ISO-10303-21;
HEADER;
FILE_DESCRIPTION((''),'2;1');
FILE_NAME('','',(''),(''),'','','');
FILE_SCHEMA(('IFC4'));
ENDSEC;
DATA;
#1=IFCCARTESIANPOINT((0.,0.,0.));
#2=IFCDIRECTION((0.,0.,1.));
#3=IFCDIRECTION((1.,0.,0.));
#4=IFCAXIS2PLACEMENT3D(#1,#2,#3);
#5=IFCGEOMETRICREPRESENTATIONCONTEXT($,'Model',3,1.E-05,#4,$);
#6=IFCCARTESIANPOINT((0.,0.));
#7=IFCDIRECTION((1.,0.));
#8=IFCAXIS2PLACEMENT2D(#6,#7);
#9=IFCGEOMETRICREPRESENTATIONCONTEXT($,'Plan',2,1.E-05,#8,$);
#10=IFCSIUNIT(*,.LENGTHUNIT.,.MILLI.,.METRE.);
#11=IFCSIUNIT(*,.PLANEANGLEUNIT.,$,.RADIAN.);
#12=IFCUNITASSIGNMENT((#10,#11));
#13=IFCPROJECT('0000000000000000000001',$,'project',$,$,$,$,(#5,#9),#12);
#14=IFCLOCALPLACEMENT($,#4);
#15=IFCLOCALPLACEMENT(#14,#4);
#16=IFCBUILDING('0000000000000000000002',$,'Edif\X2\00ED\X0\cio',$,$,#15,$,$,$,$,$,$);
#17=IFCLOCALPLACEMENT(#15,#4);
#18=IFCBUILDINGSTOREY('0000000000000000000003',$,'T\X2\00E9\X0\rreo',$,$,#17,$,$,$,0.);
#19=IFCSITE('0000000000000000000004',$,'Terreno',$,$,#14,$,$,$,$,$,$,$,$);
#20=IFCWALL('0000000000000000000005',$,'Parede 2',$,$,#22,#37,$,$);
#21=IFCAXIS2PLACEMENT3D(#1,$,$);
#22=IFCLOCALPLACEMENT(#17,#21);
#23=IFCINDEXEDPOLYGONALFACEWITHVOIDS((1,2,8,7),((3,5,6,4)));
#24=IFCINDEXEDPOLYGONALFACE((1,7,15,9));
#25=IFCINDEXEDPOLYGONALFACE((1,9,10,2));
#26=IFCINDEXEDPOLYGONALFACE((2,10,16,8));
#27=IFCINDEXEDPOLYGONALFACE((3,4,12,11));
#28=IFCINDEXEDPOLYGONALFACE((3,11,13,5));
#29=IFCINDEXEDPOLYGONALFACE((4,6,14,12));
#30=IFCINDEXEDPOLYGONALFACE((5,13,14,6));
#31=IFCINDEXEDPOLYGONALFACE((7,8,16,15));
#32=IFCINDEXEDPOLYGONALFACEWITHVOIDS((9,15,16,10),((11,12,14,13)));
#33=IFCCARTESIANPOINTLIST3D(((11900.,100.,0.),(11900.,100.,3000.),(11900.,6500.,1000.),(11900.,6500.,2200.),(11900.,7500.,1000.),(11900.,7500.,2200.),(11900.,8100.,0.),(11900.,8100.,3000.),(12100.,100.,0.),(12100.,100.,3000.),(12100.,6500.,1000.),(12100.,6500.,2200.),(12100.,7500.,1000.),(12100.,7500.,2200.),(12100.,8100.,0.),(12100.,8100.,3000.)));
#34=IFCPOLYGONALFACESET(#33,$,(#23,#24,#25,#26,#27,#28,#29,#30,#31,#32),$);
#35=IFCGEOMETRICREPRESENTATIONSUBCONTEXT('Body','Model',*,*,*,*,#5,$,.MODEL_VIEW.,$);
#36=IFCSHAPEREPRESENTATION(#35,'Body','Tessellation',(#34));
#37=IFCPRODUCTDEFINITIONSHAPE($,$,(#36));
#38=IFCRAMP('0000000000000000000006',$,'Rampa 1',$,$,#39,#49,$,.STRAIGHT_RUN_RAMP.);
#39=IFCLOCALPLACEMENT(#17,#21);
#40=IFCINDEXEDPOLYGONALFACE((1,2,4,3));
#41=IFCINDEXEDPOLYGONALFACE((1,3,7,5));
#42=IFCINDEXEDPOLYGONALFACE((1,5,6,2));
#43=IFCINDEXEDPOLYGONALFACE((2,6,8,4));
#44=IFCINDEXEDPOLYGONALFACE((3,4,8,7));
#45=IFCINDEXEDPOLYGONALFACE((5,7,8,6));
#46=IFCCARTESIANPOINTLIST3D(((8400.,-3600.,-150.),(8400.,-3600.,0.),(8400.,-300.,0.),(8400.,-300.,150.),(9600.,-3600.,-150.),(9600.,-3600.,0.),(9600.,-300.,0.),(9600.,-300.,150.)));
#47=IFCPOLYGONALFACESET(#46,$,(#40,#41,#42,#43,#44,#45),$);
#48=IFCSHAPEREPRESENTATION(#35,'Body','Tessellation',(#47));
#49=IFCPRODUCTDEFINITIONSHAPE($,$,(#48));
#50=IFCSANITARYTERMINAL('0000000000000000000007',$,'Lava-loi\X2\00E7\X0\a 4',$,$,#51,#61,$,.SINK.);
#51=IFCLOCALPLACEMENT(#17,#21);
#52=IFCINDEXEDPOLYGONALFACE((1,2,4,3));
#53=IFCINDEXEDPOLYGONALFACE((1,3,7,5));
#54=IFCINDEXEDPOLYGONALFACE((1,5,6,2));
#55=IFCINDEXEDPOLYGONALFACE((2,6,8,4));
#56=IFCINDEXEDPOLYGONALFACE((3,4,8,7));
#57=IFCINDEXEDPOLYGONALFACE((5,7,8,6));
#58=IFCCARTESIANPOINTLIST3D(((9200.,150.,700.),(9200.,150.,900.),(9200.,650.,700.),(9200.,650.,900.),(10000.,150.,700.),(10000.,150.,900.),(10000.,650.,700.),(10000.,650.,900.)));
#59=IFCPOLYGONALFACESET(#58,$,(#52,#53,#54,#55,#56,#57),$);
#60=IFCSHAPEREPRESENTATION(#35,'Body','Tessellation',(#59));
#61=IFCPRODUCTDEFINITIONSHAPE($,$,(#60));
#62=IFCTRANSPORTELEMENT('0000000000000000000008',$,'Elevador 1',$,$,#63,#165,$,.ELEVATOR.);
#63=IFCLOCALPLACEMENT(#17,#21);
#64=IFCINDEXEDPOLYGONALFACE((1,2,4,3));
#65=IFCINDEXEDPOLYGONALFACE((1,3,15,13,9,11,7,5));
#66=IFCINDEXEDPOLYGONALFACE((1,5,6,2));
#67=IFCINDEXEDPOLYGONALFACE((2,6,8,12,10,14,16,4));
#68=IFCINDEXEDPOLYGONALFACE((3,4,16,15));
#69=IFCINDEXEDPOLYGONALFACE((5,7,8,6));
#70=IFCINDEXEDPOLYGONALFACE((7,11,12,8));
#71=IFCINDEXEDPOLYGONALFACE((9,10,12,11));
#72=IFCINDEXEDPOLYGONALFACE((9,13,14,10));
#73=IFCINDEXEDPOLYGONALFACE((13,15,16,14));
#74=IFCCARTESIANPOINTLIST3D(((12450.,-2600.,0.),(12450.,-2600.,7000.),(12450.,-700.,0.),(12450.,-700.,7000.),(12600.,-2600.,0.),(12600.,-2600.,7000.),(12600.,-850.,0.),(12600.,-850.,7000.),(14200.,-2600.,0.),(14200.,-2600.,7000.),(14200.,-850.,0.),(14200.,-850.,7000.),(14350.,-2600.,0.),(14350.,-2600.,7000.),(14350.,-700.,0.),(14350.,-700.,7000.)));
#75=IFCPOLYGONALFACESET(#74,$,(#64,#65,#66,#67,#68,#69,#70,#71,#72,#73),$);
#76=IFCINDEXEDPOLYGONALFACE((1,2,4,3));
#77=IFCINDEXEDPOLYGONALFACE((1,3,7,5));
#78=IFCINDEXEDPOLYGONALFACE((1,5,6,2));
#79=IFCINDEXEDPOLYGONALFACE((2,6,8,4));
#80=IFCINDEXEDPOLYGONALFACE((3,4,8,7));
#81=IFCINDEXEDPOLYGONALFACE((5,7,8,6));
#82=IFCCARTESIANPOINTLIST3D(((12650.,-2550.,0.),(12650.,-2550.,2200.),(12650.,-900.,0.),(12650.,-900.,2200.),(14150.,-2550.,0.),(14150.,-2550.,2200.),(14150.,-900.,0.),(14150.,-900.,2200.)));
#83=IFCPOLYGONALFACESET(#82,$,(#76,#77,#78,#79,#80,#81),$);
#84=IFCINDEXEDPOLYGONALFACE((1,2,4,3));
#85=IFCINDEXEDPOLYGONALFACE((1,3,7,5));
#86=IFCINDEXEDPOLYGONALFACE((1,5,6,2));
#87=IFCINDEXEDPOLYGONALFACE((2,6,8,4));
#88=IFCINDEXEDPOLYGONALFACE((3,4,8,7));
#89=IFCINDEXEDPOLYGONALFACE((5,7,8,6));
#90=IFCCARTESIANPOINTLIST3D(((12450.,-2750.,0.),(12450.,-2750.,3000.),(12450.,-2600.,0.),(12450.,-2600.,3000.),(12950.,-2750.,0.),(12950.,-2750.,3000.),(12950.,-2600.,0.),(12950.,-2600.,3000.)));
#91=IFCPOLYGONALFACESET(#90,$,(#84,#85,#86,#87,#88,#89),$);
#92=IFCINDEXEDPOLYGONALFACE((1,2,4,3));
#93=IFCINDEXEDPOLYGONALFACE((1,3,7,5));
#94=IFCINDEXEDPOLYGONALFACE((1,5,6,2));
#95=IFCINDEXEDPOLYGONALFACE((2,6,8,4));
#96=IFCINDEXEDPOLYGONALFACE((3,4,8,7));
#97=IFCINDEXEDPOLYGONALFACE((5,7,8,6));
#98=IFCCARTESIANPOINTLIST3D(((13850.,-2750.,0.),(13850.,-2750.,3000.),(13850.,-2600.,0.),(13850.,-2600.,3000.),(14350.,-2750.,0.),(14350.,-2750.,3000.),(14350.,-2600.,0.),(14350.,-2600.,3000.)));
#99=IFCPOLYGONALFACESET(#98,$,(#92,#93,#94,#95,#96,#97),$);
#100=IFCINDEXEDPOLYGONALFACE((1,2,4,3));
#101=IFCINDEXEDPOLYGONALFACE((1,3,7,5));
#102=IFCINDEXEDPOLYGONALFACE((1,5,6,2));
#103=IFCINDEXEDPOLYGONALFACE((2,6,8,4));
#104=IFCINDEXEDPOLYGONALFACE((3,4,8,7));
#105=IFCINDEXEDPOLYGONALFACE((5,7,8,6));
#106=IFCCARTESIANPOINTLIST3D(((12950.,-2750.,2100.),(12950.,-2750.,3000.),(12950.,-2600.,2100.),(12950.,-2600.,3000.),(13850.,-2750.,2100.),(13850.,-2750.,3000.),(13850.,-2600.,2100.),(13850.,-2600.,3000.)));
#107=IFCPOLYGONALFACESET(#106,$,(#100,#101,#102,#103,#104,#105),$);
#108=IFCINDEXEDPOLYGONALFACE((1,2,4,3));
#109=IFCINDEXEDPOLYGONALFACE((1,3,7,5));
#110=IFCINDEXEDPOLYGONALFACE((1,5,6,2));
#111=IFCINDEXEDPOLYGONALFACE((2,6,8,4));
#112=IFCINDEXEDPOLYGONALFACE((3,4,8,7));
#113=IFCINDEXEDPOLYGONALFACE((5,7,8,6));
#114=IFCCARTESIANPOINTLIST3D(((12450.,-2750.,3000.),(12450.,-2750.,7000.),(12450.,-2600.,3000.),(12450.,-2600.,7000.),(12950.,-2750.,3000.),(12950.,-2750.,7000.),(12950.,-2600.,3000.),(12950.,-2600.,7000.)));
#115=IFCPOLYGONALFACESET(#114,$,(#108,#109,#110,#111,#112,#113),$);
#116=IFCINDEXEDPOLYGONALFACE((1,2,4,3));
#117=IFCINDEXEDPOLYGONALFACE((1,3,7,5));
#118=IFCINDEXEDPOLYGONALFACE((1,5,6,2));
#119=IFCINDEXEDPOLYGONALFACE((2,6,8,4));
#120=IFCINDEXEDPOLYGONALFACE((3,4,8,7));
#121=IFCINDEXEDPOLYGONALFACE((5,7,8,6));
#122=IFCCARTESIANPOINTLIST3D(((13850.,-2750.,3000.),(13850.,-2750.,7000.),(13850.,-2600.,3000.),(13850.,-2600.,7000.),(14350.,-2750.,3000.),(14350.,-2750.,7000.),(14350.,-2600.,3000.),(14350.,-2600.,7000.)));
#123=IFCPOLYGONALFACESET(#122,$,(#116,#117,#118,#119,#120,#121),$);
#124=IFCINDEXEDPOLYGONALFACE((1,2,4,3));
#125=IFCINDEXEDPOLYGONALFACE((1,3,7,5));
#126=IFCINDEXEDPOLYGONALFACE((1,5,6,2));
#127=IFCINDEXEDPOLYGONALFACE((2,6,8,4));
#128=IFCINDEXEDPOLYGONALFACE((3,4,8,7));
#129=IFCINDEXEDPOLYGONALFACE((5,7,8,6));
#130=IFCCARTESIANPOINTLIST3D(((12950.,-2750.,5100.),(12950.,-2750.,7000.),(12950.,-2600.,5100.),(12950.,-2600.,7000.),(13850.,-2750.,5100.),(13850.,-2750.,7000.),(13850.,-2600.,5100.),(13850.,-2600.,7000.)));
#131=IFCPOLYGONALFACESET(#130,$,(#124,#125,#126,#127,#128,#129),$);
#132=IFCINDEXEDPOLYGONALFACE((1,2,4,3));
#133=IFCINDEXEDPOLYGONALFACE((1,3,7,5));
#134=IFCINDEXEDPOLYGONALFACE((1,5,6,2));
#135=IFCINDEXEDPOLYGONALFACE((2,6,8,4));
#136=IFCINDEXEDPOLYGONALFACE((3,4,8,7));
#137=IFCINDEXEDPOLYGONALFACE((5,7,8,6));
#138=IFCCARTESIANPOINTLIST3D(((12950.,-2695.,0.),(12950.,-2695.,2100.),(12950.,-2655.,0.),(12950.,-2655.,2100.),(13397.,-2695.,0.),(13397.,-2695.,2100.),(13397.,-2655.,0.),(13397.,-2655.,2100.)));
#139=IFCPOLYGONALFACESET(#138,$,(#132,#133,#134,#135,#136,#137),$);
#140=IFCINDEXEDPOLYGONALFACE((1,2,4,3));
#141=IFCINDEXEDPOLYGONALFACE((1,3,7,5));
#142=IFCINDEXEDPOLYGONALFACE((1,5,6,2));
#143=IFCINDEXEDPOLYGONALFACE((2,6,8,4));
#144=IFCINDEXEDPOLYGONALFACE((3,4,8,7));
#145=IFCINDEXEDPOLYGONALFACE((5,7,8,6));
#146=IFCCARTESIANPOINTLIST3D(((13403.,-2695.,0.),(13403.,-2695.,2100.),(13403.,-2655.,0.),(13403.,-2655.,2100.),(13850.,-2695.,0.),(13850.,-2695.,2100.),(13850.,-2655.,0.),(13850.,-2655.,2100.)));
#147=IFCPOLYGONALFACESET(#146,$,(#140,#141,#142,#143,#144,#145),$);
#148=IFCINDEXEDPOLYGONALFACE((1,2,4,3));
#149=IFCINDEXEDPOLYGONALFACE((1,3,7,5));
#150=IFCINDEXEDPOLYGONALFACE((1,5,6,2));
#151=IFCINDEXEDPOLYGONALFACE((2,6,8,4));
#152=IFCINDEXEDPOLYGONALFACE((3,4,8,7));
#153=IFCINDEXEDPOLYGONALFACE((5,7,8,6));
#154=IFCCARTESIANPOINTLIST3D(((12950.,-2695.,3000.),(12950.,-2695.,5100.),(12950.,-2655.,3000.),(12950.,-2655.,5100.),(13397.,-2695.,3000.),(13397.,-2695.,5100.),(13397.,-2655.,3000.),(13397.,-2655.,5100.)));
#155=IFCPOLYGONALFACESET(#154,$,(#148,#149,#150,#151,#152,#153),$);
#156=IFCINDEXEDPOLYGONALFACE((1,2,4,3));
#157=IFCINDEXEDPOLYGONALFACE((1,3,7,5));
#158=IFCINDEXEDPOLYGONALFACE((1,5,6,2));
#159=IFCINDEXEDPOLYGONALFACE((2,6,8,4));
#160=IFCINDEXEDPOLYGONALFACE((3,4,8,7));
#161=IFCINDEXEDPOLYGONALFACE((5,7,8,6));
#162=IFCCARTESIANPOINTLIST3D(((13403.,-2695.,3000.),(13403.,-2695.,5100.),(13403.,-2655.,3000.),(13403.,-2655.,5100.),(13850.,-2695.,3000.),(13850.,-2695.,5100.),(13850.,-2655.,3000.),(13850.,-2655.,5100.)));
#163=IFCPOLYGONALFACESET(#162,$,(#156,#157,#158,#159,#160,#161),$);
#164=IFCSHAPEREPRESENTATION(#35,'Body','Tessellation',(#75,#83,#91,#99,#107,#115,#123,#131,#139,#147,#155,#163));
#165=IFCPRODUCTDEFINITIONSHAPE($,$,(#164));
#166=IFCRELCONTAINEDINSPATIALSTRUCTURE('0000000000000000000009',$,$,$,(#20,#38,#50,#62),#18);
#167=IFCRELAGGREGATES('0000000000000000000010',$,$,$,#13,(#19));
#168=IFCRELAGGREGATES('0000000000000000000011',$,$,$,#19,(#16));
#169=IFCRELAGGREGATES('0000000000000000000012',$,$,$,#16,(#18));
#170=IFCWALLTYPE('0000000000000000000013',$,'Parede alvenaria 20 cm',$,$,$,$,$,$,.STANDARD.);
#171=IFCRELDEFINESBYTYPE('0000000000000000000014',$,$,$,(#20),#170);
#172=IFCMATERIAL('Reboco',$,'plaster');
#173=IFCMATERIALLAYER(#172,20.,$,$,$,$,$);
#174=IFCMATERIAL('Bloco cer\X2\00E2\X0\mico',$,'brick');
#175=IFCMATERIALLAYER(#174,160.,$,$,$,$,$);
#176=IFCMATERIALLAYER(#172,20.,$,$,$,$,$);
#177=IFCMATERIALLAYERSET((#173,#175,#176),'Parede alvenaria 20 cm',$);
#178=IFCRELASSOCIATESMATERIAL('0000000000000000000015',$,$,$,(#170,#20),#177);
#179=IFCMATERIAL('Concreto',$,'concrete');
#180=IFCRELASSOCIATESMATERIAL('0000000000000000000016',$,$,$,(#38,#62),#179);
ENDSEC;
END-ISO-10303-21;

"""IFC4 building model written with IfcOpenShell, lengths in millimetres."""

from ifc_helpers import new_model, si_unit, frame, frame_2d, origin_with_axes, origin_2d_with_axis, place, context, subcontext, project, spatial, indexed_curve, rectangle, outline, extrude, material, layer, layer_set, layer_usage, type_object, element, save


model = new_model("IFC4")

# Units and contexts
model_context = context("Model", 3, precision=1e-05, world=origin_with_axes())
plan_context = context("Plan", 2, precision=1e-05, world=origin_2d_with_axis())
body_context = subcontext(model_context, "Body", "Model", "MODEL_VIEW")
ifc_project = project(units=[si_unit("LENGTHUNIT", "METRE", prefix="MILLI"), si_unit("PLANEANGLEUNIT", "RADIAN")], contexts=[model_context, plan_context])

# Site, building, storey
site_placement = place(None, origin_with_axes())
site = spatial("IfcSite", under=ifc_project, at=site_placement, Name="Terreno")
building_placement = place(site_placement, origin_with_axes())
building = spatial("IfcBuilding", under=site, at=building_placement, Name="Edifício")
storey_placement = place(building_placement, origin_with_axes())
storey = spatial("IfcBuildingStorey", under=building, at=storey_placement, Name="Térreo", Elevation=0.0)

# Wall, opening
ifc_material_1 = material(Name="Reboco", Category="plaster")
ifc_layer_1 = layer(ifc_material_1, 20.0)
ifc_material_2 = material(Name="Bloco cerâmico", Category="brick")
ifc_layer_2 = layer(ifc_material_2, 160.0)
ifc_layer_3 = layer(ifc_material_1, 20.0)
ifc_layer_set = layer_set([ifc_layer_1, ifc_layer_2, ifc_layer_3], Name="Parede alvenaria 20 cm")
ifc_layer_usage = layer_usage(ifc_layer_set, "AXIS2", "POSITIVE", -100.0)
wall_type = type_object("IfcWallType", Name="Parede alvenaria 20 cm", PredefinedType="STANDARD", material=ifc_layer_set)
wall_placement = place(storey_placement, frame((12000.0, 100.0, 0.0), z_axis=(0.0, 0.0, 1.0), x_axis=(0.0, 1.0, 0.0)))
wall = element("IfcWall", 1, at=wall_placement, inside=storey, type_object=wall_type, material=ifc_layer_usage, Name="Parede 2", context=body_context, shape_type="SweptSolid", body=[
    extrude(outline(indexed_curve([(0.0, 0.0), (0.0, 200.0), (8000.0, 200.0), (8000.0, 0.0), (0.0, 0.0)], self_intersect=False)), frame((0.0, -100.0, 0.0), z_axis=(0.0, 0.0, 1.0), x_axis=(1.0, 0.0, 0.0)), (0.0, 0.0, 1.0), 3000.0),
])
opening_placement = place(wall_placement, frame((6400.0, -110.0, 1000.0), z_axis=(0.0, 0.0, 1.0), x_axis=(1.0, 0.0, 0.0)))
element("IfcOpeningElement", 2, at=opening_placement, cuts=wall, context=body_context, shape_type="SweptSolid", body=[
    extrude(outline(indexed_curve([(0.0, 0.0), (0.0, 220.0), (1000.0, 220.0), (1000.0, 0.0), (0.0, 0.0)], self_intersect=False)), origin_with_axes(), (0.0, 0.0, 1.0), 1200.0),
])

# Ramp
ifc_material_3 = material(Name="Concreto", Category="concrete")
ramp_placement = place(storey_placement, frame((9000.0, -3600.0, 0.0), z_axis=(0.0, 0.0, 1.0), x_axis=(0.0, 1.0, 0.0)))
element("IfcRamp", 3, at=ramp_placement, inside=storey, material=ifc_material_3, Name="Rampa 1", PredefinedType="STRAIGHT_RUN_RAMP", context=body_context, shape_type="SweptSolid", body=[
    extrude(outline(indexed_curve([(0.0, 0.0), (3300.0, 150.0), (3300.0, 0.0), (0.0, -150.0), (0.0, 0.0)], self_intersect=False)), frame((0.0, 600.0, 0.0), z_axis=(0.0, -1.0, 0.0), x_axis=(1.0, 0.0, 0.0)), (0.0, 0.0, 1.0), 1200.0),
])

# Sanitary terminal
sanitary_terminal_placement = place(storey_placement, frame((9600.0, 100.0, 0.0), z_axis=(0.0, 0.0, 1.0), x_axis=(1.0, 0.0, 0.0)))
element("IfcSanitaryTerminal", 4, at=sanitary_terminal_placement, inside=storey, Name="Lava-loiça 4", PredefinedType="SINK", context=body_context, shape_type="SweptSolid", body=[
    extrude(rectangle(XDim=800.0, YDim=500.0, at=frame_2d((0.0, 300.0))), frame((0.0, 0.0, 700.0)), (0.0, 0.0, 1.0), 200.0),
])

# Transport element
transport_element_placement = place(storey_placement, frame((12600.0, -2600.0, 0.0), z_axis=(0.0, 0.0, 1.0), x_axis=(1.0, 0.0, 0.0)))
element("IfcTransportElement", 5, at=transport_element_placement, inside=storey, material=ifc_material_3, Name="Elevador 1", PredefinedType="ELEVATOR", context=body_context, shape_type="SweptSolid", body=[
    extrude(outline(indexed_curve([(-150.0, 0.0), (0.0, 0.0), (0.0, 1750.0), (1600.0, 1750.0), (1600.0, 0.0), (1750.0, 0.0), (1750.0, 1900.0), (-150.0, 1900.0), (-150.0, 0.0)], self_intersect=False)), origin_with_axes(), (0.0, 0.0, 1.0), 7000.0),
    extrude(outline(indexed_curve([(50.0, 50.0), (1550.0, 50.0), (1550.0, 1700.0), (50.0, 1700.0), (50.0, 50.0)], self_intersect=False)), origin_with_axes(), (0.0, 0.0, 1.0), 2200.0),
    extrude(outline(indexed_curve([(-150.0, -150.0), (350.0, -150.0), (350.0, 0.0), (-150.0, 0.0), (-150.0, -150.0)], self_intersect=False)), origin_with_axes(), (0.0, 0.0, 1.0), 3000.0),
    extrude(outline(indexed_curve([(1250.0, -150.0), (1750.0, -150.0), (1750.0, 0.0), (1250.0, 0.0), (1250.0, -150.0)], self_intersect=False)), origin_with_axes(), (0.0, 0.0, 1.0), 3000.0),
    extrude(outline(indexed_curve([(350.0, -150.0), (1250.0, -150.0), (1250.0, 0.0), (350.0, 0.0), (350.0, -150.0)], self_intersect=False)), frame((0.0, 0.0, 2100.0), z_axis=(0.0, 0.0, 1.0), x_axis=(1.0, 0.0, 0.0)), (0.0, 0.0, 1.0), 900.0),
    extrude(outline(indexed_curve([(-150.0, -150.0), (350.0, -150.0), (350.0, 0.0), (-150.0, 0.0), (-150.0, -150.0)], self_intersect=False)), frame((0.0, 0.0, 3000.0), z_axis=(0.0, 0.0, 1.0), x_axis=(1.0, 0.0, 0.0)), (0.0, 0.0, 1.0), 4000.0),
    extrude(outline(indexed_curve([(1250.0, -150.0), (1750.0, -150.0), (1750.0, 0.0), (1250.0, 0.0), (1250.0, -150.0)], self_intersect=False)), frame((0.0, 0.0, 3000.0), z_axis=(0.0, 0.0, 1.0), x_axis=(1.0, 0.0, 0.0)), (0.0, 0.0, 1.0), 4000.0),
    extrude(outline(indexed_curve([(350.0, -150.0), (1250.0, -150.0), (1250.0, 0.0), (350.0, 0.0), (350.0, -150.0)], self_intersect=False)), frame((0.0, 0.0, 5100.0), z_axis=(0.0, 0.0, 1.0), x_axis=(1.0, 0.0, 0.0)), (0.0, 0.0, 1.0), 1900.0),
    extrude(outline(indexed_curve([(350.0, -95.0), (797.0, -95.0), (797.0, -55.0), (350.0, -55.0), (350.0, -95.0)], self_intersect=False)), origin_with_axes(), (0.0, 0.0, 1.0), 2100.0),
    extrude(outline(indexed_curve([(803.0, -95.0), (1250.0, -95.0), (1250.0, -55.0), (803.0, -55.0), (803.0, -95.0)], self_intersect=False)), origin_with_axes(), (0.0, 0.0, 1.0), 2100.0),
    extrude(outline(indexed_curve([(350.0, -95.0), (797.0, -95.0), (797.0, -55.0), (350.0, -55.0), (350.0, -95.0)], self_intersect=False)), frame((0.0, 0.0, 3000.0), z_axis=(0.0, 0.0, 1.0), x_axis=(1.0, 0.0, 0.0)), (0.0, 0.0, 1.0), 2100.0),
    extrude(outline(indexed_curve([(803.0, -95.0), (1250.0, -95.0), (1250.0, -55.0), (803.0, -55.0), (803.0, -95.0)], self_intersect=False)), frame((0.0, 0.0, 3000.0), z_axis=(0.0, 0.0, 1.0), x_axis=(1.0, 0.0, 0.0)), (0.0, 0.0, 1.0), 2100.0),
])

save(model, "model.ifc")
